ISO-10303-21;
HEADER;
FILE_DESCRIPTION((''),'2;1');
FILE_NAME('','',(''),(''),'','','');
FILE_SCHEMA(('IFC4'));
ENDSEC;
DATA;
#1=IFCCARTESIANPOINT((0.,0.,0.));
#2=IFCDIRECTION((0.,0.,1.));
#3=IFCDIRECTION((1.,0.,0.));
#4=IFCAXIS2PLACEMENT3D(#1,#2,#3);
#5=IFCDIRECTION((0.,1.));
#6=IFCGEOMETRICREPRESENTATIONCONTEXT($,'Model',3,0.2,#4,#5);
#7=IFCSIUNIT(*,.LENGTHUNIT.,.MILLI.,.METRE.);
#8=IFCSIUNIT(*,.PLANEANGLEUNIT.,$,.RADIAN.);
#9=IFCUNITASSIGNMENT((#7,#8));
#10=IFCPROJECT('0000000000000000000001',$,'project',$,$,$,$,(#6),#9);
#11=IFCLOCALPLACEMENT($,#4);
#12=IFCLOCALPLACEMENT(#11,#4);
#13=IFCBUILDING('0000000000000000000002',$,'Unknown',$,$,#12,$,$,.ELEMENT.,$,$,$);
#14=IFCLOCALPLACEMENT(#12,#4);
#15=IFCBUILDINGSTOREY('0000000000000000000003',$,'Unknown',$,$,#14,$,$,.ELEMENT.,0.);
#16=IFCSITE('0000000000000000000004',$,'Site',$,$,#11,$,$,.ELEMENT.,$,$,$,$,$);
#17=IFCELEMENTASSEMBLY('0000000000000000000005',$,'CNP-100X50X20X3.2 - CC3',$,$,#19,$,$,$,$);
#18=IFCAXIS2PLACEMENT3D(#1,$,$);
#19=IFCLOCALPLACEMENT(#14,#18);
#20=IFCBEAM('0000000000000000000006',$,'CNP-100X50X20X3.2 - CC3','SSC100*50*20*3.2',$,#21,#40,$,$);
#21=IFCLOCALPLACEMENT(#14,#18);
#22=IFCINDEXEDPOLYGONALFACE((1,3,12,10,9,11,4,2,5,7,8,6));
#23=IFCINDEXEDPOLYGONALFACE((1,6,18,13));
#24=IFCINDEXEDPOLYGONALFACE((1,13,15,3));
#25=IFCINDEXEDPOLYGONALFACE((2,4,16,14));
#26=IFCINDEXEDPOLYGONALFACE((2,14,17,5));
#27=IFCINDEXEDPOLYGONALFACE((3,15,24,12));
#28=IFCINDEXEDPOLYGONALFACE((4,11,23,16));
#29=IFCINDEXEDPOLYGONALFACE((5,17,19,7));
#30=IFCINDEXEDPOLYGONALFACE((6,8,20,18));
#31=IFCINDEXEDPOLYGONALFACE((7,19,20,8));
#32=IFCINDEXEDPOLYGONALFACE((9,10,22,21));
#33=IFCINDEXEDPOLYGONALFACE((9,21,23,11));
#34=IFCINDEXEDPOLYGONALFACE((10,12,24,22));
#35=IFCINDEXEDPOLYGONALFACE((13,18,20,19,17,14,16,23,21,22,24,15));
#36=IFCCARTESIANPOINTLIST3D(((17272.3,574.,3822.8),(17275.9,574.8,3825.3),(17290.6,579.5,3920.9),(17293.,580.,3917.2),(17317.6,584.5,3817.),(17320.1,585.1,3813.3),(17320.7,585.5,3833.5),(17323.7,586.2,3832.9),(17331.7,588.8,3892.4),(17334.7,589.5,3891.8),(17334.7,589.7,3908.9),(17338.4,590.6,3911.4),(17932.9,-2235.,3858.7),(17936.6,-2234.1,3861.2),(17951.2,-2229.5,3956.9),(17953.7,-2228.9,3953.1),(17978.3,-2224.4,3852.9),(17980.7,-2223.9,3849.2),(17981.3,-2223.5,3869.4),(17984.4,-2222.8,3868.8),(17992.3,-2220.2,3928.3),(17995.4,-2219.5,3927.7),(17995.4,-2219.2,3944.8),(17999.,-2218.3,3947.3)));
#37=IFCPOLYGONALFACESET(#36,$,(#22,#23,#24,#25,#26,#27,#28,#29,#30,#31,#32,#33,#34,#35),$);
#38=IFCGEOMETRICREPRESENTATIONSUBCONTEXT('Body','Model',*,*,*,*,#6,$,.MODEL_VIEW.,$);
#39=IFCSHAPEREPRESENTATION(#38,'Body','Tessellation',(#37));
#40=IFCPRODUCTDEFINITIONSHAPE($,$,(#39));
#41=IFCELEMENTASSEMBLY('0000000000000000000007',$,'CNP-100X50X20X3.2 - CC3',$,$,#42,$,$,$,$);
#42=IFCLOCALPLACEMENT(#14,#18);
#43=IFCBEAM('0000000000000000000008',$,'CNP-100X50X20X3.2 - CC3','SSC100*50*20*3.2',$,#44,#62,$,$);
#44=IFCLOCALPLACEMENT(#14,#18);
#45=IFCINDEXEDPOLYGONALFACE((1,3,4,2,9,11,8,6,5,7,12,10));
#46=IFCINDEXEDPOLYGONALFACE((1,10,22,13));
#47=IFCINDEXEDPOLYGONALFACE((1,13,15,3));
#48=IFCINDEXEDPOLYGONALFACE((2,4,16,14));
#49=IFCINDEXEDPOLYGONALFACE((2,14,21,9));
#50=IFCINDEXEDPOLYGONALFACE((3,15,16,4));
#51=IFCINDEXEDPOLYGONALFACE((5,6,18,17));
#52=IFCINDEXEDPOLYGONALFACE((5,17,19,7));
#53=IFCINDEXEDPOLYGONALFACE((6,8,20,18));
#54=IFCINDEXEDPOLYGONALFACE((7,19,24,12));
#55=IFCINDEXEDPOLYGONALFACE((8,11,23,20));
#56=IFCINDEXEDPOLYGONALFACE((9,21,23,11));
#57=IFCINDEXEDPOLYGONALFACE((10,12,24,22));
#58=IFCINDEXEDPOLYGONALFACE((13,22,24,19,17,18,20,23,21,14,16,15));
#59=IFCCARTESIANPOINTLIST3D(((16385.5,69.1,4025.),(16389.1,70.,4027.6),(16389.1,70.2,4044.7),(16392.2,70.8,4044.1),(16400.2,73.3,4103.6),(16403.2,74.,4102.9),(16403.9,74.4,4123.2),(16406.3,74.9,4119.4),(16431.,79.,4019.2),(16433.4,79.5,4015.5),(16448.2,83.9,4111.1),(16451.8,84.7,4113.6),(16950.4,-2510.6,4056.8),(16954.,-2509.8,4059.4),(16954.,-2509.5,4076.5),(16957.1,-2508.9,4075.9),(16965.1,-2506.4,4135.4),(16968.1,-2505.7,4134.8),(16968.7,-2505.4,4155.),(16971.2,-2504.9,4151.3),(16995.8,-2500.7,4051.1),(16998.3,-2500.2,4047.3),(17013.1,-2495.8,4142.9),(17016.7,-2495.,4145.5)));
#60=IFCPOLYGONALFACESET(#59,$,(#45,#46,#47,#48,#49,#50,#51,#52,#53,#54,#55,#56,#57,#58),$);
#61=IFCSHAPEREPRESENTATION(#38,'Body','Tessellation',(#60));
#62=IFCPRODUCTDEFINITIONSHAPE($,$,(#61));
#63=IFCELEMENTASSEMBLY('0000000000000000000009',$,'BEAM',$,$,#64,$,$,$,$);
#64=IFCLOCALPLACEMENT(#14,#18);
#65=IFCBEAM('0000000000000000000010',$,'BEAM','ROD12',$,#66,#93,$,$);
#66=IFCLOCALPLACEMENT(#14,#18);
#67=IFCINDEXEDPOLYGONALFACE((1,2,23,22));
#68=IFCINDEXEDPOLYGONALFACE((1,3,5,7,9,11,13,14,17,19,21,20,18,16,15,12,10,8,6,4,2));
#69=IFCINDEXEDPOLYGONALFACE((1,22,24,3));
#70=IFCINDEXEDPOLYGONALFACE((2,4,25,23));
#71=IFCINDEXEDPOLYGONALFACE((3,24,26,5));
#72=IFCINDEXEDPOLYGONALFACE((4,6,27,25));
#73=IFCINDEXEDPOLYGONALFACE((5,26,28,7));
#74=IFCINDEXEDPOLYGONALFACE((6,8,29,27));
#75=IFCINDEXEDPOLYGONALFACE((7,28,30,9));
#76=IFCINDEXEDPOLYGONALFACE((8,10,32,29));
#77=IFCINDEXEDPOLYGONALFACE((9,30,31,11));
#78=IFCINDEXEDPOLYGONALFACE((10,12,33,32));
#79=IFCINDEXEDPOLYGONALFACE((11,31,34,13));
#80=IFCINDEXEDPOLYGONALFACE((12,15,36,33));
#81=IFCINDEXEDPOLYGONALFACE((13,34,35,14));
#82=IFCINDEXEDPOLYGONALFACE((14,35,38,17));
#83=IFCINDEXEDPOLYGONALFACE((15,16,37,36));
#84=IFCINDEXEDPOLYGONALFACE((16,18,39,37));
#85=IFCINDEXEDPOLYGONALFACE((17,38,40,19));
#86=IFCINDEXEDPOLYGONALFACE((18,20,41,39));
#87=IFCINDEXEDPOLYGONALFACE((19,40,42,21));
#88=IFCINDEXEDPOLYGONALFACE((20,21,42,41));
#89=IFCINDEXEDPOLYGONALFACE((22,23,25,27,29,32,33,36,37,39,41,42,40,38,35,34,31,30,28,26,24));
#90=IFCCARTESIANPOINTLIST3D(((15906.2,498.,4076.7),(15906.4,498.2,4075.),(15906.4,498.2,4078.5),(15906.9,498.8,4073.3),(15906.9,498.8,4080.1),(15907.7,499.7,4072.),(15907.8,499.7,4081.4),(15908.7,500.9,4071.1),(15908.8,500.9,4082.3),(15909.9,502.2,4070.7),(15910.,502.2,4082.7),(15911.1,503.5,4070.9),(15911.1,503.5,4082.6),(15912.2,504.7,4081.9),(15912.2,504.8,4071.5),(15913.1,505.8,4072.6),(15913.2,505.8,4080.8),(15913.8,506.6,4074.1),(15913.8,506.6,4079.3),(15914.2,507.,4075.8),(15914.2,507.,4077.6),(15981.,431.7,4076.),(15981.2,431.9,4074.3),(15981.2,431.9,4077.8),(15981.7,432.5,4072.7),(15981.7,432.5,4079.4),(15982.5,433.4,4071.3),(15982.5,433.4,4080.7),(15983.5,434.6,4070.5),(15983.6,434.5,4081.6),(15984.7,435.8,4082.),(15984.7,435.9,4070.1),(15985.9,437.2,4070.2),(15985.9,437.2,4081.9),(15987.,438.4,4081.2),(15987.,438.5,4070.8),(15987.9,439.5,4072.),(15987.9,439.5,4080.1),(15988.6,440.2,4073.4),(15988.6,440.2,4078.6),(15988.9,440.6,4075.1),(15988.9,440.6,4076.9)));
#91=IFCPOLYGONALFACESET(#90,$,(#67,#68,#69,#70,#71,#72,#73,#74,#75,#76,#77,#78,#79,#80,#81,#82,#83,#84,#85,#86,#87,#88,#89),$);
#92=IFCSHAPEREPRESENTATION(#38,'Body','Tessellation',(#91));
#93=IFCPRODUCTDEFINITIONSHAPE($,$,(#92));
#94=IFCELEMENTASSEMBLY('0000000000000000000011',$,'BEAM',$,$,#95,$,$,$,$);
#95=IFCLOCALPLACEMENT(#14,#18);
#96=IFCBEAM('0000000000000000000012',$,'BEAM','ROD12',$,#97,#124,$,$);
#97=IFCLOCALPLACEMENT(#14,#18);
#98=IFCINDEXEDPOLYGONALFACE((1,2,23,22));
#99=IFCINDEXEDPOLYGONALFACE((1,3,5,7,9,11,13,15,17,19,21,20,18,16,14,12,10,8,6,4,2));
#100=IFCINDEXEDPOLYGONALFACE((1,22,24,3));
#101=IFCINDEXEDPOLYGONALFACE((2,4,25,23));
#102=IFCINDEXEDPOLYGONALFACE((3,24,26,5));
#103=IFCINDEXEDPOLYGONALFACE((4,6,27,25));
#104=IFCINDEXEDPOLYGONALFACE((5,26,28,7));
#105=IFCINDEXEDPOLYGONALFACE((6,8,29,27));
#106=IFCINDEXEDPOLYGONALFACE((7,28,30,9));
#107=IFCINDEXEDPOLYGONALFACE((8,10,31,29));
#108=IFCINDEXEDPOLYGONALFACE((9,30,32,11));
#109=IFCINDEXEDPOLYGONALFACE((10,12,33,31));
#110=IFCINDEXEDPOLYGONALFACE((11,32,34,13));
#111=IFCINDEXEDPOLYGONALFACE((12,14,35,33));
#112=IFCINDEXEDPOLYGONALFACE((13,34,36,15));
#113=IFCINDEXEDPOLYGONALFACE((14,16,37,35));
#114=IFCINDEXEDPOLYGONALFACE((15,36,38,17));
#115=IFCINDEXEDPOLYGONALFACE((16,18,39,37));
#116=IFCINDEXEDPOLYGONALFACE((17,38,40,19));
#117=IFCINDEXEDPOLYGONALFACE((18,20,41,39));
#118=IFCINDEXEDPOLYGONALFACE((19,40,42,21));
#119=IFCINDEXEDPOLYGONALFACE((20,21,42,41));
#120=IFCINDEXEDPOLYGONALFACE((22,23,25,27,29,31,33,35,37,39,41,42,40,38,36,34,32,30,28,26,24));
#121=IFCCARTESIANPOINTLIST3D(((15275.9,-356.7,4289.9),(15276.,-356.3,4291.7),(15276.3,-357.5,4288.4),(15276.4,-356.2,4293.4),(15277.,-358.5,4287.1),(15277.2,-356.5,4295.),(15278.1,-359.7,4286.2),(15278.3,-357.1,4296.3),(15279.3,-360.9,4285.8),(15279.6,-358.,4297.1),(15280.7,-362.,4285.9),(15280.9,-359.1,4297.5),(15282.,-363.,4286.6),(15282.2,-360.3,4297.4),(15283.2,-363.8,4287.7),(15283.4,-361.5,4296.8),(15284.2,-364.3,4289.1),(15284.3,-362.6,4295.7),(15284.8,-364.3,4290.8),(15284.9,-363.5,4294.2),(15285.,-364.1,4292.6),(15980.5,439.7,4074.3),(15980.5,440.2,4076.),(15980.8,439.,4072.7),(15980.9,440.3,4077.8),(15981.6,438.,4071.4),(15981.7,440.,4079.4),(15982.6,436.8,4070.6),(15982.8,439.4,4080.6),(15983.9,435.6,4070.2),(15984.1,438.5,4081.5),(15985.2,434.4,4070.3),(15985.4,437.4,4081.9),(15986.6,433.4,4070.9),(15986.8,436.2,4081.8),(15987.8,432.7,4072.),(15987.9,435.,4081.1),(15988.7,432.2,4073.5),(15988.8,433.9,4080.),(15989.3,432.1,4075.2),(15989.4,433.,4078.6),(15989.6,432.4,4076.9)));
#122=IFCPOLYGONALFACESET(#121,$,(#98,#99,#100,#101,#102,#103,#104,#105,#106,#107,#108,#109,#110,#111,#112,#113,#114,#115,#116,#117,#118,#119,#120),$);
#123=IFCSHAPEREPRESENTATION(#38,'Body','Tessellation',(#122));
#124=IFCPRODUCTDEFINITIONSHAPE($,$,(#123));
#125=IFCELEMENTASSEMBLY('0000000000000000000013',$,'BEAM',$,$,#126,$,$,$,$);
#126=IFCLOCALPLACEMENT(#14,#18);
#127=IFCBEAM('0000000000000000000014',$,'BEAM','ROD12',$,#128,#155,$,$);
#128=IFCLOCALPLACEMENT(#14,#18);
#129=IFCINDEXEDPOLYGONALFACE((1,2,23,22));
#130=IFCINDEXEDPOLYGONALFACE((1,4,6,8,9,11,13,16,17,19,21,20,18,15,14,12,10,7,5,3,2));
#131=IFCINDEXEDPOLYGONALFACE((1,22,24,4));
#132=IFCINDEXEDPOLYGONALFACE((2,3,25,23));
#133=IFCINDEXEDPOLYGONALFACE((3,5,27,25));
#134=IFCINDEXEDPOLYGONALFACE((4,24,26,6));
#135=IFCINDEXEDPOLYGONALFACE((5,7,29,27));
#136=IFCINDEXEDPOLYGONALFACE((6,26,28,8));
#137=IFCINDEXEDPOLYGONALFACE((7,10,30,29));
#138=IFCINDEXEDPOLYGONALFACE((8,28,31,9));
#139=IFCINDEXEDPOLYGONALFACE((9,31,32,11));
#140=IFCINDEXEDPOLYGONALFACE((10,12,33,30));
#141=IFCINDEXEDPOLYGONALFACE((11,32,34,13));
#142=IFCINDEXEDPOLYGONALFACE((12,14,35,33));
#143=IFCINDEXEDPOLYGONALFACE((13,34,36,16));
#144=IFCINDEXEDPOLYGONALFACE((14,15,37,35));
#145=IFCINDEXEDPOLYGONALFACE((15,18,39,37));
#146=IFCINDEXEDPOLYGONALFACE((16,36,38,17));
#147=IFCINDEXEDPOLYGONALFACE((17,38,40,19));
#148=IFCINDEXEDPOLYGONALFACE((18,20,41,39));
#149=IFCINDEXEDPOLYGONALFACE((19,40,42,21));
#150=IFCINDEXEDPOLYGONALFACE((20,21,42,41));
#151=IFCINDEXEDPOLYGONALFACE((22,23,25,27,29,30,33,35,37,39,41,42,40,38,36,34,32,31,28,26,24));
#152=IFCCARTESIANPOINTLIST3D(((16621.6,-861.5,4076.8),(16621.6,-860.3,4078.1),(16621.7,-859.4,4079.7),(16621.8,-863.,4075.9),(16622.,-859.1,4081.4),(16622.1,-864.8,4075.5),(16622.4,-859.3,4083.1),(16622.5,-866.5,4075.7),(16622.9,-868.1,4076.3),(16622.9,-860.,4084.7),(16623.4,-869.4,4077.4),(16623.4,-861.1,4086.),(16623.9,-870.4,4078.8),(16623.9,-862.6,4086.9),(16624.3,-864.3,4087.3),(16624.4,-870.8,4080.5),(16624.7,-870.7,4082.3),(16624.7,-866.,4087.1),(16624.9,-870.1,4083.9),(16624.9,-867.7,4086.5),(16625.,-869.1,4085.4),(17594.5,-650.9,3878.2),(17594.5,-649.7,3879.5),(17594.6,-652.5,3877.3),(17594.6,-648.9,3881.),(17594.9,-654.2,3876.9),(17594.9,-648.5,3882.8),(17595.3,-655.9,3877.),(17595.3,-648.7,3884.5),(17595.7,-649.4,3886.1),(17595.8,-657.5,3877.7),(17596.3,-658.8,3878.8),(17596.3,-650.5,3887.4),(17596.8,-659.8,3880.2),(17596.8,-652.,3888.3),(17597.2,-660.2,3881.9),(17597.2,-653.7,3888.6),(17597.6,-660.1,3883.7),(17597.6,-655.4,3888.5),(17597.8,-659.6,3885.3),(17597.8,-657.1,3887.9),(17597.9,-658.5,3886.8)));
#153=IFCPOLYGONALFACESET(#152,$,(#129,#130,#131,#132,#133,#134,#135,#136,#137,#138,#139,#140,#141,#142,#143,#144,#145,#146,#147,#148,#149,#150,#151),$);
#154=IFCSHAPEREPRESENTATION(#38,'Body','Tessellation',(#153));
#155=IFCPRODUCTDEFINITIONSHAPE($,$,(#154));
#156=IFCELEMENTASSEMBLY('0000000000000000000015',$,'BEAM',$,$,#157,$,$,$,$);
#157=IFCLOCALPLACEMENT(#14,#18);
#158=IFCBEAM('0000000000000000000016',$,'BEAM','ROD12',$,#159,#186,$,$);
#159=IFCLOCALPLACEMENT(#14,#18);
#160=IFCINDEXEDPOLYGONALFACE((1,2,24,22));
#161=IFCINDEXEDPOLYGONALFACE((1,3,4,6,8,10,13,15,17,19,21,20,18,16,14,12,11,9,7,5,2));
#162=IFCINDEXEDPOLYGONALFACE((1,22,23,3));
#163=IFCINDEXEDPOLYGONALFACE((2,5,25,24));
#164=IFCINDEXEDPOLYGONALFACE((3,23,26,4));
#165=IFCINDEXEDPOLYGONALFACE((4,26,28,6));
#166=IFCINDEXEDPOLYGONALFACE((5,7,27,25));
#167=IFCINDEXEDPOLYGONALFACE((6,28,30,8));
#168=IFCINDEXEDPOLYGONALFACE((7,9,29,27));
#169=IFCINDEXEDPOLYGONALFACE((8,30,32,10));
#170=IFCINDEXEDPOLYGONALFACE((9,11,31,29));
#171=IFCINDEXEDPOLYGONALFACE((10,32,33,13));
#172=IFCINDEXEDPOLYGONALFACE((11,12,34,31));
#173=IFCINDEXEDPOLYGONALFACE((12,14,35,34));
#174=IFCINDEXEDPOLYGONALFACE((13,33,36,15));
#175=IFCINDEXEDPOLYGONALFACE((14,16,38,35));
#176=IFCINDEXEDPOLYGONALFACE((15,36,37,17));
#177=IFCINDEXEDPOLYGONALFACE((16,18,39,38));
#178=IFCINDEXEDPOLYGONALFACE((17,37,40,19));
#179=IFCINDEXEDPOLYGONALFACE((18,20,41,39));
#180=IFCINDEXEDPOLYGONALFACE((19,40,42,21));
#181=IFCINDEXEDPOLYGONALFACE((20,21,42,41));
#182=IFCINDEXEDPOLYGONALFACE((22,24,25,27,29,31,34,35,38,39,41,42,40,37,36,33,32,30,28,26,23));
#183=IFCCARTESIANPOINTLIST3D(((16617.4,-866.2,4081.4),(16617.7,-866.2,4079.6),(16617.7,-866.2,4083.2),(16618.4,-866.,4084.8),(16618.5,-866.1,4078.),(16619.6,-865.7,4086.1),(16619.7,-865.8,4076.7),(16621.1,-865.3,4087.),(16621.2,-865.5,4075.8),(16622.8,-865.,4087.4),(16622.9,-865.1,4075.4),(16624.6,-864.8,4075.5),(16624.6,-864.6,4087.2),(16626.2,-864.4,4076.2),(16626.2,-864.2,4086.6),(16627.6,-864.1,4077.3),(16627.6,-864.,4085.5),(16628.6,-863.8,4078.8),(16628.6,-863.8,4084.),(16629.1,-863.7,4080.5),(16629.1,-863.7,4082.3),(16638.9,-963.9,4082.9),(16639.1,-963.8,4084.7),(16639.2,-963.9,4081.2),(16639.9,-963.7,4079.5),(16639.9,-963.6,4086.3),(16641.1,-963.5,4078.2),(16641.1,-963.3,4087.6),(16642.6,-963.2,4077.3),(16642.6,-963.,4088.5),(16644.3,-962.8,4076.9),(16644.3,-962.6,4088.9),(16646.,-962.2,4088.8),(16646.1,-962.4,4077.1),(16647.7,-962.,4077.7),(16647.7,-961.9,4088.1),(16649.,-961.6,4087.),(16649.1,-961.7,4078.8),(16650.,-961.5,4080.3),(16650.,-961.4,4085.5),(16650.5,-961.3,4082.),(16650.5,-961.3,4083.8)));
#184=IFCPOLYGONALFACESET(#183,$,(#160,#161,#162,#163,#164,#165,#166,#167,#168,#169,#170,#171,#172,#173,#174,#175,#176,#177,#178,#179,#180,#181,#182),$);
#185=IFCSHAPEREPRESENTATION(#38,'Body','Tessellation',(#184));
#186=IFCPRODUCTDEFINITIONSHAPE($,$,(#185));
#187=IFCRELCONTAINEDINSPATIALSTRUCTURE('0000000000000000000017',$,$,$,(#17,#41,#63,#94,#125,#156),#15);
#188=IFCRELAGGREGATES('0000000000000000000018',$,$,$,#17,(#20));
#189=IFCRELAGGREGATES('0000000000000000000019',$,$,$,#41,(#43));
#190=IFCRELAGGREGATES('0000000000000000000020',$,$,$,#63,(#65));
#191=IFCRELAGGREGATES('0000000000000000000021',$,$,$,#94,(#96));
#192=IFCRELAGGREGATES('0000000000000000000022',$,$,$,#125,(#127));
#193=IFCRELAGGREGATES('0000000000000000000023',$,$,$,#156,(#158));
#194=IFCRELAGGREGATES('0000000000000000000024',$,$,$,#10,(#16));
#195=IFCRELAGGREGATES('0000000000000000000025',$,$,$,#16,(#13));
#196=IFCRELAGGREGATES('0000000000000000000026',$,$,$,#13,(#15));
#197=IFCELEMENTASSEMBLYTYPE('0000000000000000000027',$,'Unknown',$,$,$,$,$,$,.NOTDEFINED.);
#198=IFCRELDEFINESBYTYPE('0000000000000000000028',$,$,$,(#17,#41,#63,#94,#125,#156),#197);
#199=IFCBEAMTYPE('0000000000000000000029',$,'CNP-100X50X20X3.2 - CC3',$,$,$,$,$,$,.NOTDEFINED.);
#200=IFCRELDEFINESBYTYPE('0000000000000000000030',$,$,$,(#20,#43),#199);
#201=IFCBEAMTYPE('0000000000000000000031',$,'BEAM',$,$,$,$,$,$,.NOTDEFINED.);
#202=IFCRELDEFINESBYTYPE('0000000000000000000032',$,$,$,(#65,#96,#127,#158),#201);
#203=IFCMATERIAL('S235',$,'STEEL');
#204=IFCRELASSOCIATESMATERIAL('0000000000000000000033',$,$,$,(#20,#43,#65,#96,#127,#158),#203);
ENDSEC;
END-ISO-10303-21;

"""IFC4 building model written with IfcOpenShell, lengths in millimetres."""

from ifc_helpers import new_model, si_unit, direction, frame, origin_with_axes, origin_2d_with_axis, place, context, subcontext, project, spatial, circle, c_section, extrude, material, material_profile, profile_set, profile_usage, type_object, element, aggregate, save


model = new_model("IFC4")

# Units and contexts
model_context = context("Model", 3, precision=0.2, world=origin_with_axes(), true_north=direction((0.0, 1.0)))
body_context = subcontext(model_context, "Body", "Model", "MODEL_VIEW")
ifc_project = project(units=[si_unit("LENGTHUNIT", "METRE", prefix="MILLI"), si_unit("PLANEANGLEUNIT", "RADIAN")], contexts=[model_context])

# Site, building, storey
site_placement = place(None, origin_with_axes())
site = spatial("IfcSite", under=ifc_project, at=site_placement, Name="Site", CompositionType="ELEMENT")
building_placement = place(site_placement, origin_with_axes())
building = spatial("IfcBuilding", under=site, at=building_placement, Name="Unknown", CompositionType="ELEMENT")
storey_placement = place(building_placement, origin_with_axes())
storey = spatial("IfcBuildingStorey", under=building, at=storey_placement, Name="Unknown", CompositionType="ELEMENT", Elevation=0.0)

# Element assemblies, beams
element_assembly_type = type_object("IfcElementAssemblyType", Name="Unknown", PredefinedType="NOTDEFINED")
assembly_1_placement = place(storey_placement, frame((17305.3, 582.3, 3867.1), z_axis=(0.956098, 0.222427, -0.190794), x_axis=(0.228927, -0.973364, 0.012441)))
assembly_1 = element("IfcElementAssembly", 1, at=assembly_1_placement, inside=storey, type_object=element_assembly_type, Name="CNP-100X50X20X3.2 - CC3")
ifc_material_1 = material(Name="S235", Category="STEEL")
ifc_material_profile_1 = material_profile(ifc_material_1, c_section(Depth=100.0, Width=50.0, WallThickness=3.2, Girth=20.0, at=origin_2d_with_axis()), Name="SSC100*50*20*3.2")
ifc_profile_set_1 = profile_set([ifc_material_profile_1])
ifc_profile_usage_1 = profile_usage(ifc_profile_set_1, cardinal=1)
beam_type_1 = type_object("IfcBeamType", Name="CNP-100X50X20X3.2 - CC3", PredefinedType="NOTDEFINED")
beam_1_placement = place(assembly_1_placement, origin_with_axes())
beam_1 = element("IfcBeam", 2, at=beam_1_placement, type_object=beam_type_1, material=ifc_profile_usage_1, Name="CNP-100X50X20X3.2 - CC3", Description="SSC100*50*20*3.2", context=body_context, shape_type="SolidModel", body=[
    extrude(c_section(Depth=100.0, Width=50.0, WallThickness=3.2, Girth=20.0, at=origin_2d_with_axis()), frame((0.0, 0.0, 0.0), z_axis=(-1.0, 0.0, 0.0), x_axis=(0.0, 0.0, 1.0)), (0.0, 0.0, -1.0), 2885.8),
])
aggregate(assembly_1, [beam_1])
assembly_2_placement = place(storey_placement, frame((16418.6, 76.9, 4069.3), z_axis=(-0.959399, -0.20773, 0.190795), x_axis=(0.21389, -0.976784, 0.012046)))
assembly_2 = element("IfcElementAssembly", 3, at=assembly_2_placement, inside=storey, type_object=element_assembly_type, Name="CNP-100X50X20X3.2 - CC3")
ifc_profile_usage_2 = profile_usage(ifc_profile_set_1, cardinal=4)
beam_2_placement = place(assembly_2_placement, origin_with_axes())
beam_2 = element("IfcBeam", 4, at=beam_2_placement, type_object=beam_type_1, material=ifc_profile_usage_2, Name="CNP-100X50X20X3.2 - CC3", Description="SSC100*50*20*3.2", context=body_context, shape_type="SolidModel", body=[
    extrude(c_section(Depth=100.0, Width=50.0, WallThickness=3.2, Girth=20.0, at=origin_2d_with_axis()), frame((0.0, 0.0, 0.0), z_axis=(-1.0, 0.0, 0.0), x_axis=(0.0, 0.0, 1.0)), (0.0, 0.0, -1.0), 2641.0),
])
aggregate(assembly_2, [beam_2])
assembly_3_placement = place(storey_placement, frame((15910.2, 502.5, 4076.7), z_axis=(-0.663593, -0.748094, 0.0), x_axis=(0.748077, -0.663577, -0.006849)))
assembly_3 = element("IfcElementAssembly", 5, at=assembly_3_placement, inside=storey, type_object=element_assembly_type, Name="BEAM")
ifc_material_profile_2 = material_profile(ifc_material_1, circle(Radius=6.0, at=origin_2d_with_axis()), Name="ROD12")
ifc_profile_set_2 = profile_set([ifc_material_profile_2])
ifc_profile_usage_3 = profile_usage(ifc_profile_set_2, cardinal=5)
beam_type_2 = type_object("IfcBeamType", Name="BEAM", PredefinedType="NOTDEFINED")
beam_3_placement = place(assembly_3_placement, origin_with_axes())
beam_3 = element("IfcBeam", 6, at=beam_3_placement, type_object=beam_type_2, material=ifc_profile_usage_3, Name="BEAM", Description="ROD12", context=body_context, shape_type="SolidModel", body=[
    extrude(circle(Radius=6.0, at=origin_2d_with_axis()), frame((0.0, 0.0, 0.0), z_axis=(-1.0, 0.0, 0.0), x_axis=(0.0, 0.0, 1.0)), (0.0, 0.0, -1.0), 100.0),
])
aggregate(assembly_3, [beam_3])
assembly_4_placement = place(storey_placement, frame((15985.0, 436.2, 4076.0), z_axis=(-0.749015, 0.662553, 0.0), x_axis=(-0.649336, -0.734074, 0.198743)))
assembly_4 = element("IfcElementAssembly", 7, at=assembly_4_placement, inside=storey, type_object=element_assembly_type, Name="BEAM")
beam_4_placement = place(assembly_4_placement, origin_with_axes())
beam_4 = element("IfcBeam", 8, at=beam_4_placement, type_object=beam_type_2, material=ifc_profile_usage_3, Name="BEAM", Description="ROD12", context=body_context, shape_type="SolidModel", body=[
    extrude(circle(Radius=6.0, at=origin_2d_with_axis()), frame((0.0, 0.0, 0.0), z_axis=(-1.0, 0.0, 0.0), x_axis=(0.0, 0.0, 1.0)), (0.0, 0.0, -1.0), 1085.0),
])
aggregate(assembly_4, [beam_4])
assembly_5_placement = place(storey_placement, frame((17596.1, -654.4, 3882.8), z_axis=(-0.211556, 0.977366, 0.0), x_axis=(-0.958473, -0.207467, 0.195673)))
assembly_5 = element("IfcElementAssembly", 9, at=assembly_5_placement, inside=storey, type_object=element_assembly_type, Name="BEAM")
beam_5_placement = place(assembly_5_placement, origin_with_axes())
beam_5 = element("IfcBeam", 10, at=beam_5_placement, type_object=beam_type_2, material=ifc_profile_usage_3, Name="BEAM", Description="ROD12", context=body_context, shape_type="SolidModel", body=[
    extrude(circle(Radius=6.0, at=origin_2d_with_axis()), frame((0.0, 0.0, 0.0), z_axis=(-1.0, 0.0, 0.0), x_axis=(0.0, 0.0, 1.0)), (0.0, 0.0, -1.0), 1015.0),
])
aggregate(assembly_5, [beam_5])
assembly_6_placement = place(storey_placement, frame((16623.3, -865.0, 4081.4), z_axis=(-0.976712, -0.214556, 0.0), x_axis=(0.214531, -0.976596, 0.015387)))
assembly_6 = element("IfcElementAssembly", 11, at=assembly_6_placement, inside=storey, type_object=element_assembly_type, Name="BEAM")
beam_6_placement = place(assembly_6_placement, origin_with_axes())
beam_6 = element("IfcBeam", 12, at=beam_6_placement, type_object=beam_type_2, material=ifc_profile_usage_3, Name="BEAM", Description="ROD12", context=body_context, shape_type="SolidModel", body=[
    extrude(circle(Radius=6.0, at=origin_2d_with_axis()), frame((0.0, 0.0, 0.0), z_axis=(-1.0, 0.0, 0.0), x_axis=(0.0, 0.0, 1.0)), (0.0, 0.0, -1.0), 100.0),
])
aggregate(assembly_6, [beam_6])

save(model, "model.ifc")
